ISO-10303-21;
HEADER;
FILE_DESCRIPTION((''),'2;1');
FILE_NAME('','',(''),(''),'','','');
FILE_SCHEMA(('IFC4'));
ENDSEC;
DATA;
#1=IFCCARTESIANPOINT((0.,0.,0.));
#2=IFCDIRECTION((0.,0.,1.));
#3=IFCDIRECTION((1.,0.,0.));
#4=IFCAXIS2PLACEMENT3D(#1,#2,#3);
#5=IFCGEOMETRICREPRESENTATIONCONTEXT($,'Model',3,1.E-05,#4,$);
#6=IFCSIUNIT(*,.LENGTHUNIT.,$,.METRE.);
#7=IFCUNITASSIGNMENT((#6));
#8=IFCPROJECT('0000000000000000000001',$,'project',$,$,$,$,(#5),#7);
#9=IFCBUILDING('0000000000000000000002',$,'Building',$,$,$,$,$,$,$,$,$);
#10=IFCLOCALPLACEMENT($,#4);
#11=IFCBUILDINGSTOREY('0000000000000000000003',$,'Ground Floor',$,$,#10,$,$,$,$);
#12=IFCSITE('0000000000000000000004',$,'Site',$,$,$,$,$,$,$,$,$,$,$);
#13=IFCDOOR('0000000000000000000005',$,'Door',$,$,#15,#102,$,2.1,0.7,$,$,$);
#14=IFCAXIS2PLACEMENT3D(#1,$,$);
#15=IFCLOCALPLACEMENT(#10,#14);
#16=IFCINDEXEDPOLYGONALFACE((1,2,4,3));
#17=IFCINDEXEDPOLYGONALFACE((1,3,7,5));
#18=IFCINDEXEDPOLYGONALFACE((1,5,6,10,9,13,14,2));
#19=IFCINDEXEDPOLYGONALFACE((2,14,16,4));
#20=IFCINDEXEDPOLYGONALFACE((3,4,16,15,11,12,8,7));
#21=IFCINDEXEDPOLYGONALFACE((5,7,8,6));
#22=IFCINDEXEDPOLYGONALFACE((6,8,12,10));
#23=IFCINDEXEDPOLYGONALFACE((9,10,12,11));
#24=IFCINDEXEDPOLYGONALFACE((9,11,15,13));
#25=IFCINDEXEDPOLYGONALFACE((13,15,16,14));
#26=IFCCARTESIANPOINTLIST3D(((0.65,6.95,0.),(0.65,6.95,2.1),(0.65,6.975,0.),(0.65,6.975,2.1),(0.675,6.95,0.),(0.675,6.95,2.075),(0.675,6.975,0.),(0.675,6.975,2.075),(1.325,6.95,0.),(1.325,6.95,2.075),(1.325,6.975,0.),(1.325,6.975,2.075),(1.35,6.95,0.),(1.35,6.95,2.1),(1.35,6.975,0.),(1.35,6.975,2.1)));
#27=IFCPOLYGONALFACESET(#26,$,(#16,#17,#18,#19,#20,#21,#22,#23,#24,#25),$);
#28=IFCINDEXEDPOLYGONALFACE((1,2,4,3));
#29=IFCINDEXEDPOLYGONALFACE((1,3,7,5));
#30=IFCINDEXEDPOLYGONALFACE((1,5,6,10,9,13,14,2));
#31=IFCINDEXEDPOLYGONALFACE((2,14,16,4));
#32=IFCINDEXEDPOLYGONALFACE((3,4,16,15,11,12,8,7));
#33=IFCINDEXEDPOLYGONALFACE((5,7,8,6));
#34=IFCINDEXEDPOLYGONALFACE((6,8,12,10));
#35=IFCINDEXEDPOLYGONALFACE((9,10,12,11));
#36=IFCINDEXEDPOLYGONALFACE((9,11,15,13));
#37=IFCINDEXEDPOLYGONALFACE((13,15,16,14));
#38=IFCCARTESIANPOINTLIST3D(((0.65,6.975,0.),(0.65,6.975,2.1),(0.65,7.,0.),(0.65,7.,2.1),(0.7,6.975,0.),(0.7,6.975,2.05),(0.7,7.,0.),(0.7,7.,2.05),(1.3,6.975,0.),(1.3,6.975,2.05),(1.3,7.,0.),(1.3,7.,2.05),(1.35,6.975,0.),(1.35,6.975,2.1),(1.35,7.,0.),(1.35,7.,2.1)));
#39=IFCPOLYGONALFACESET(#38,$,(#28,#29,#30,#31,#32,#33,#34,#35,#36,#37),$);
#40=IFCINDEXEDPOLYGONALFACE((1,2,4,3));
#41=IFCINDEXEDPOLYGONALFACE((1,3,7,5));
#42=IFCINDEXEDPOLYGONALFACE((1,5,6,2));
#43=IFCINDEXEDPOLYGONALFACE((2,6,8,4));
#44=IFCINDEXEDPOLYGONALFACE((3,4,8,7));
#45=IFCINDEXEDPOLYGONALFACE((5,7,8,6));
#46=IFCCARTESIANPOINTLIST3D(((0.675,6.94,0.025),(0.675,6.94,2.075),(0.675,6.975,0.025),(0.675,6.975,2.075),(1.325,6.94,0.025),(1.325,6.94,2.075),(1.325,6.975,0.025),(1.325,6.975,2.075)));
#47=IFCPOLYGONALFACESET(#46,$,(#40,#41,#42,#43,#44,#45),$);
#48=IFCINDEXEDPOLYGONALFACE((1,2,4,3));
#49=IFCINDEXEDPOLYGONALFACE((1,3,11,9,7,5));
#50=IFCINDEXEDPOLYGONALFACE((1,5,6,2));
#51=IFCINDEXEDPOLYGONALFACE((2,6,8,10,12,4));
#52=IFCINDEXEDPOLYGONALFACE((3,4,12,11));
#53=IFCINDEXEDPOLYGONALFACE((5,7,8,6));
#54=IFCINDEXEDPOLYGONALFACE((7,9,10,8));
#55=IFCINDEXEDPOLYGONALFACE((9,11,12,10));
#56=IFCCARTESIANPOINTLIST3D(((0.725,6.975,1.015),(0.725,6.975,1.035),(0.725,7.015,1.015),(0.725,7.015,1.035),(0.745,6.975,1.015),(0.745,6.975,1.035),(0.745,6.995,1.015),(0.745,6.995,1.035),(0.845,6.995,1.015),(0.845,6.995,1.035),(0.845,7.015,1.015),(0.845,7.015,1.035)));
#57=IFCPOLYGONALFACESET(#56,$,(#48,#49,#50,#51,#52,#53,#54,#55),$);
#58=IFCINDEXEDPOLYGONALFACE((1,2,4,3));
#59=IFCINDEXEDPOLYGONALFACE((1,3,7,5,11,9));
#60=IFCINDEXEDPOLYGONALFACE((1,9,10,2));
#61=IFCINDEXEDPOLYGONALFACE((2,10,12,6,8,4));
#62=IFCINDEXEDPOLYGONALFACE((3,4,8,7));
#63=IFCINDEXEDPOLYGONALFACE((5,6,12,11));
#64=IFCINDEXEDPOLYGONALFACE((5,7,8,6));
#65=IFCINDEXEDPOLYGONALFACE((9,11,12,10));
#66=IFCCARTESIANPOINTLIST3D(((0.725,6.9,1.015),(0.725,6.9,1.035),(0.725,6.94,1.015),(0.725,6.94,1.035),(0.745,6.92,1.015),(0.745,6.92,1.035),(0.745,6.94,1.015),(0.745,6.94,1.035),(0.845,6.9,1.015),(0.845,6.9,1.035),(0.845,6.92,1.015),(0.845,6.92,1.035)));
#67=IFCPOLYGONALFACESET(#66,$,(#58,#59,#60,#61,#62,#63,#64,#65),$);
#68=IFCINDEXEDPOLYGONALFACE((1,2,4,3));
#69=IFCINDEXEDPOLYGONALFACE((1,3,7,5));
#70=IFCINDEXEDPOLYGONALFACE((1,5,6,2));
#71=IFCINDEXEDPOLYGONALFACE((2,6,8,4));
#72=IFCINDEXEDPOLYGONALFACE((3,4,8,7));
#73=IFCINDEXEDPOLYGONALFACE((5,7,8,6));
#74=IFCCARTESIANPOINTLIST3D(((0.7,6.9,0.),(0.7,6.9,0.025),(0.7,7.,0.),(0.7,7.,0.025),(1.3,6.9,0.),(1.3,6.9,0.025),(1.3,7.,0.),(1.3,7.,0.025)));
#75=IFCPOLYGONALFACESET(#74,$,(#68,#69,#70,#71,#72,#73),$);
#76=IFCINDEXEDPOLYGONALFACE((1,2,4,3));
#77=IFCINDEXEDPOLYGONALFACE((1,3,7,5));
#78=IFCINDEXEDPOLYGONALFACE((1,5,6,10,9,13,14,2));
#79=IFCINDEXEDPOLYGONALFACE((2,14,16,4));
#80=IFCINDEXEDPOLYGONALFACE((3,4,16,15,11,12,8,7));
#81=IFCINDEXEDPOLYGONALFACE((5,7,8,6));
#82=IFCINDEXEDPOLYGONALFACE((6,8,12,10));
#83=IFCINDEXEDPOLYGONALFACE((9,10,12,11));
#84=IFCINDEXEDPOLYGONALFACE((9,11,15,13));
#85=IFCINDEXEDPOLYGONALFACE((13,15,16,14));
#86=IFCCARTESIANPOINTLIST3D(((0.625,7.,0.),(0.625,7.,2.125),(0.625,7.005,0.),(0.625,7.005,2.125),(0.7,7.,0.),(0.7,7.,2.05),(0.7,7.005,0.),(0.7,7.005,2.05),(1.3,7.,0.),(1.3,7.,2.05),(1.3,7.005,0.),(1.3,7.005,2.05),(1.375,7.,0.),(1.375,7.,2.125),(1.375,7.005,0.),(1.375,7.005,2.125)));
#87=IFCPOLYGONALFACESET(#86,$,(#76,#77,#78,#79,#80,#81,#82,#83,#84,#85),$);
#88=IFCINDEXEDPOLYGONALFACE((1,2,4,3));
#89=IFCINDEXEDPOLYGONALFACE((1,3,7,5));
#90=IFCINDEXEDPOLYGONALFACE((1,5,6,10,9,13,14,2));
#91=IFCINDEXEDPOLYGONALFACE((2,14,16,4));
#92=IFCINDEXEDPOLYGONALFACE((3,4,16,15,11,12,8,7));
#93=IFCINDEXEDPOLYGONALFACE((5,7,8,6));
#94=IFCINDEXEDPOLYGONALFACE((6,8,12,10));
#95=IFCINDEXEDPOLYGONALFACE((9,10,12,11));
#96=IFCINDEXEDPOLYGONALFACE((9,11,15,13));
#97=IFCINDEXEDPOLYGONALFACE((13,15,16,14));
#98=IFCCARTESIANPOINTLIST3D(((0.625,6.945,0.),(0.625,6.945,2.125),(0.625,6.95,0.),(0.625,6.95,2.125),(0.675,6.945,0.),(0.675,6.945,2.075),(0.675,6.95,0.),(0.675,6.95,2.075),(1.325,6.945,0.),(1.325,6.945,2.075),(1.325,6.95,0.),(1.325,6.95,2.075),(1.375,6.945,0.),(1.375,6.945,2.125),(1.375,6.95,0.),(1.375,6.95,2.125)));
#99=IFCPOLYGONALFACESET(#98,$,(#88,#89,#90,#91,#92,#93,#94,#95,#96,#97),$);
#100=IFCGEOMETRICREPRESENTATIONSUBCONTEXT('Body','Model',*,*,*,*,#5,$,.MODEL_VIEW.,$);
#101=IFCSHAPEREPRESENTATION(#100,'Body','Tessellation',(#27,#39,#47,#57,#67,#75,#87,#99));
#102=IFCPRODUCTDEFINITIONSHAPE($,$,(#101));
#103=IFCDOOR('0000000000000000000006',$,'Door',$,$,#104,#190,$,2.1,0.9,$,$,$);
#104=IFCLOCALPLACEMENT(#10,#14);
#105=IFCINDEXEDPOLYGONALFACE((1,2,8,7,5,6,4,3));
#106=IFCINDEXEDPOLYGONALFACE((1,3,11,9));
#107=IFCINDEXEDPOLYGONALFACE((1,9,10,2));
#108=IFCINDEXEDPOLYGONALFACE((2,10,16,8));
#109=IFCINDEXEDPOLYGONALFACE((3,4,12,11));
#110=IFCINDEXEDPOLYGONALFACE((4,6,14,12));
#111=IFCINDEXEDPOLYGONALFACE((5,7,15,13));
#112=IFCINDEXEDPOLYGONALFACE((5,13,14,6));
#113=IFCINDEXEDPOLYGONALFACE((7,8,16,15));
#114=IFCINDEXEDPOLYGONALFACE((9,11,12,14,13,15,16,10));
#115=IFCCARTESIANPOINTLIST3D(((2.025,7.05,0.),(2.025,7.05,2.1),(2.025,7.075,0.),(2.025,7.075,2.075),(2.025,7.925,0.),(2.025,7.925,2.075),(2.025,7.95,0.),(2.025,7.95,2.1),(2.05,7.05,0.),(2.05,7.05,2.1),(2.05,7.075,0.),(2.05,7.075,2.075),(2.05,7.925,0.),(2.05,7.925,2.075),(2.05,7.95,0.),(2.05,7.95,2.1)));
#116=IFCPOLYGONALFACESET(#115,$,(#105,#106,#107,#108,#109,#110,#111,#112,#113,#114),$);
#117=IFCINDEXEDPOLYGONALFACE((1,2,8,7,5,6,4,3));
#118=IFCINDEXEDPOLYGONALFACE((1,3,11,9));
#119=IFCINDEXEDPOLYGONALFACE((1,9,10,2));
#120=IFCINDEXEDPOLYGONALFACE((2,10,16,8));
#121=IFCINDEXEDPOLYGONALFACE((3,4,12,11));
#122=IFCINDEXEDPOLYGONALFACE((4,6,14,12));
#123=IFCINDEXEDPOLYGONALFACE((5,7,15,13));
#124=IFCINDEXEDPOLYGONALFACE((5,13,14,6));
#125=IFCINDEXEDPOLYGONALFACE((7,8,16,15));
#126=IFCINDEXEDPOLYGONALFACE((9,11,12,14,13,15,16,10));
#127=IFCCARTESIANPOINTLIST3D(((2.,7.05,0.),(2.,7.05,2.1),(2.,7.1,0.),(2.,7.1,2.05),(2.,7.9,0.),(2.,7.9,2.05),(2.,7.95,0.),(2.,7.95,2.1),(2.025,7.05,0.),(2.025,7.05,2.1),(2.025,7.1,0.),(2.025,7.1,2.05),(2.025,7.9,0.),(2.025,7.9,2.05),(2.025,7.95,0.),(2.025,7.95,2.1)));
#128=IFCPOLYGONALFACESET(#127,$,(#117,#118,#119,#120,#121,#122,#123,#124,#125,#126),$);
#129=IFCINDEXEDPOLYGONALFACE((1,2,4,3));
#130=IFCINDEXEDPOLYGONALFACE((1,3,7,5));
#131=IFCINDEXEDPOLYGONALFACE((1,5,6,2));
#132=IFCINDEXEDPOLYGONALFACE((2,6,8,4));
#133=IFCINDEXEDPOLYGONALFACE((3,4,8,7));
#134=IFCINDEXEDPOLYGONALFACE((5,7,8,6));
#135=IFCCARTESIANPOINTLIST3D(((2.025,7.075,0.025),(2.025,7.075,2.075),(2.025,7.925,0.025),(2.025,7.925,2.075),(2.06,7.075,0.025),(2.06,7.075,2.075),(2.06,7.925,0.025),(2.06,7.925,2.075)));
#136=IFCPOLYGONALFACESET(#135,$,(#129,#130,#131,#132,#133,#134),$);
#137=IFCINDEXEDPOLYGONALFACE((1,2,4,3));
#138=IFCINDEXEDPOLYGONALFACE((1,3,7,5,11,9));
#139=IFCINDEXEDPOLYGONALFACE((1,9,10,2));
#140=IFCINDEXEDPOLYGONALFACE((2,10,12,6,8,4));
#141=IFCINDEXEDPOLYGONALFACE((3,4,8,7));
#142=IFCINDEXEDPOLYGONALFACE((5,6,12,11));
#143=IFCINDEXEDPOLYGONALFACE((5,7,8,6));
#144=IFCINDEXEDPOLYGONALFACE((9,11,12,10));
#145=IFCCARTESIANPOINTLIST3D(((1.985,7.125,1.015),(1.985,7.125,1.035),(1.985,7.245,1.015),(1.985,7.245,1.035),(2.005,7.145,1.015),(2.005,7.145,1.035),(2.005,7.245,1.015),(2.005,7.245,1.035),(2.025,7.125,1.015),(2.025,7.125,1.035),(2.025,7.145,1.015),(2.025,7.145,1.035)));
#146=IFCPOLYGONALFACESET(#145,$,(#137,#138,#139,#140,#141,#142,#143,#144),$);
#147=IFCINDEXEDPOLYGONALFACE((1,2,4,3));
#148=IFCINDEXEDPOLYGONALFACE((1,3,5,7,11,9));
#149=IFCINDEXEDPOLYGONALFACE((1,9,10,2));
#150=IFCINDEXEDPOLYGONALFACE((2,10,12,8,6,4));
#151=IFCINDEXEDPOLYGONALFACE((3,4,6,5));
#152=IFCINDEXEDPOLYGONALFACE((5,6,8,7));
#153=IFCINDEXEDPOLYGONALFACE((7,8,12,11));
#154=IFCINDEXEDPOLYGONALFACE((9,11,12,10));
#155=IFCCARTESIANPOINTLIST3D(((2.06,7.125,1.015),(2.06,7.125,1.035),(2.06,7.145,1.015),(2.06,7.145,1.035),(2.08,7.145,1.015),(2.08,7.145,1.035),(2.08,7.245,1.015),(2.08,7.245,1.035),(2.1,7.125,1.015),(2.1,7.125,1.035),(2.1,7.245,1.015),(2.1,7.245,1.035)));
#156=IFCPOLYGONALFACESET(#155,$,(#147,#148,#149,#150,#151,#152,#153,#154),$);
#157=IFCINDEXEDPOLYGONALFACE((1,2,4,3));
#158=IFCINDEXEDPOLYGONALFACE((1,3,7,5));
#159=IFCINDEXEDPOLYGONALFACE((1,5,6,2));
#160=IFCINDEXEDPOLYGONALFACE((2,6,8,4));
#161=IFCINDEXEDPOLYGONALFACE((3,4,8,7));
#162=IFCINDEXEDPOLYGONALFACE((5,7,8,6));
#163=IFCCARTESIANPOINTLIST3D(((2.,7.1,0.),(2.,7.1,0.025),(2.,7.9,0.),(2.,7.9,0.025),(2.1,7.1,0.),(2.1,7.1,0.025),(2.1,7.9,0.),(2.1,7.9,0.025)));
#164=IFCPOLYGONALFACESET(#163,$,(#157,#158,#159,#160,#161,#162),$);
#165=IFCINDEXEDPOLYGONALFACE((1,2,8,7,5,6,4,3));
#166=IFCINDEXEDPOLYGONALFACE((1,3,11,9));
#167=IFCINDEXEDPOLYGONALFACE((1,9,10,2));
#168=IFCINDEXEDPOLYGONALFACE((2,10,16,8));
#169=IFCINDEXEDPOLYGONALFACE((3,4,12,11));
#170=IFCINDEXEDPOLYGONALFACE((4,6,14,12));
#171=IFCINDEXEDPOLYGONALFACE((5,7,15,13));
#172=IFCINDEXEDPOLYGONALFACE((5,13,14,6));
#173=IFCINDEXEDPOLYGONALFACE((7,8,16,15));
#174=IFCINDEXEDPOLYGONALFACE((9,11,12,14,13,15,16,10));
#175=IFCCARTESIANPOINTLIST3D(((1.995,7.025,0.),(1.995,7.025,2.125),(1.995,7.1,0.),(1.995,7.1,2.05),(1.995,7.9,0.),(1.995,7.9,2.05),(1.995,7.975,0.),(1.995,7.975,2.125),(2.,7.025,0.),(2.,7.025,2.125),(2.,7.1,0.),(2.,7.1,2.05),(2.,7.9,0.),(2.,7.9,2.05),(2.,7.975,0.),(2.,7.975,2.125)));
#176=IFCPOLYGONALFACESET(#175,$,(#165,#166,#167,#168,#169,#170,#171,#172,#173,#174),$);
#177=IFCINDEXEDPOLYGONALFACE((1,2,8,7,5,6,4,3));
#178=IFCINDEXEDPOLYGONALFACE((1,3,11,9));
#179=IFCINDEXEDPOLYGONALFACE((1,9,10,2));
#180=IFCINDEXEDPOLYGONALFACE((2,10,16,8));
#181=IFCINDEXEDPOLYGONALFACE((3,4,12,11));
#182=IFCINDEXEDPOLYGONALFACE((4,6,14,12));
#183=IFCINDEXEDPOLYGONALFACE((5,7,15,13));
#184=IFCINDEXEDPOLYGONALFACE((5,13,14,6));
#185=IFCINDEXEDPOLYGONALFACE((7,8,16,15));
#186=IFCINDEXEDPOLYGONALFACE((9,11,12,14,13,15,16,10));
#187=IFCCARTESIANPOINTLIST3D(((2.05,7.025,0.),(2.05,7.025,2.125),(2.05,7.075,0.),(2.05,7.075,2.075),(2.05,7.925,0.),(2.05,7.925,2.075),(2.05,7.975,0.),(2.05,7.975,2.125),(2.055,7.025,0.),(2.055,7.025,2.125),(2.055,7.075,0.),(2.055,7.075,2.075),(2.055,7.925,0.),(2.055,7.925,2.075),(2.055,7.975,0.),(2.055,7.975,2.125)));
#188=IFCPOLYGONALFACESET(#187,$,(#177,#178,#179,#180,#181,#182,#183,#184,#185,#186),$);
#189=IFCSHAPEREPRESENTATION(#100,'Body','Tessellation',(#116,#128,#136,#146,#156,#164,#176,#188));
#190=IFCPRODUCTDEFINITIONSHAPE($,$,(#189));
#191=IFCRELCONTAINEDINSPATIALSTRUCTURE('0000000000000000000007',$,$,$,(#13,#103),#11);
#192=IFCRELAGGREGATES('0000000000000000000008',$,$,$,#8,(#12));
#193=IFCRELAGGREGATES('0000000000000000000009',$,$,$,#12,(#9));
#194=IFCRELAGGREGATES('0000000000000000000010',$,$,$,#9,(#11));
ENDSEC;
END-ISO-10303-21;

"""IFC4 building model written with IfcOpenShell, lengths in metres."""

from ifc_helpers import new_model, si_unit, frame, origin_with_axes, place, context, subcontext, project, spatial, line, indexed_curve, outline, extrude, element, save


model = new_model("IFC4")

# Units and contexts
model_context = context("Model", 3, precision=1e-05, world=origin_with_axes())
body_context = subcontext(model_context, "Body", "Model", "MODEL_VIEW")
ifc_project = project(units=[si_unit("LENGTHUNIT", "METRE")], contexts=[model_context])

# Site, building, storey
site = spatial("IfcSite", under=ifc_project, Name="Site")
building = spatial("IfcBuilding", under=site, Name="Building")
storey_placement = place(None, origin_with_axes())
storey = spatial("IfcBuildingStorey", under=building, at=storey_placement, Name="Ground Floor")

# Doors
door_1_placement = place(storey_placement, frame((1.35, 7.0, 0.0), z_axis=(0.0, 0.0, 1.0), x_axis=(-1.0, 0.0, 0.0)))
element("IfcDoor", 1, at=door_1_placement, inside=storey, Name="Door", OverallHeight=2.1, OverallWidth=0.7, context=body_context, shape_type="SweptSolid", body=[
    extrude(outline(indexed_curve([(0.0, 0.0), (0.0, 2.1), (0.7, 2.1), (0.7, 0.0), (0.675, 0.0), (0.675, 2.075), (0.025, 2.075), (0.025, 0.0)], segments=[line(1, 2, 3, 4, 5, 6, 7, 8, 1)])), frame((0.0, 0.025, 0.0), z_axis=(0.0, -1.0, 0.0), x_axis=(1.0, 0.0, 0.0)), (0.0, 0.0, -1.0), 0.025),
    extrude(outline(indexed_curve([(0.0, 0.0), (0.0, 2.1), (0.7, 2.1), (0.7, 0.0), (0.65, 0.0), (0.65, 2.05), (0.05, 2.05), (0.05, 0.0)], segments=[line(1, 2, 3, 4, 5, 6, 7, 8, 1)])), frame((0.0, 0.0, 0.0), z_axis=(0.0, -1.0, 0.0), x_axis=(1.0, 0.0, 0.0)), (0.0, 0.0, -1.0), 0.025),
    extrude(outline(indexed_curve([(0.0, 0.0), (0.65, 0.0), (0.65, 0.035), (0.0, 0.035)], segments=[line(1, 2, 3, 4, 1)])), frame((0.025, 0.025, 0.025), z_axis=(0.0, 0.0, 1.0), x_axis=(1.0, 0.0, 0.0)), (0.0, 0.0, 1.0), 2.05),
    extrude(outline(indexed_curve([(0.0, 0.0), (0.0, -0.04), (-0.12, -0.04), (-0.12, -0.02), (-0.02, -0.02), (-0.02, 0.0)], segments=[line(1, 2, 3, 4, 5, 6, 1)])), frame((0.625, 0.025, 1.015), z_axis=(0.0, 0.0, 1.0), x_axis=(1.0, 0.0, 0.0)), (0.0, 0.0, 1.0), 0.02),
    extrude(outline(indexed_curve([(0.0, 0.0), (0.0, 0.04), (-0.12, 0.04), (-0.12, 0.02), (-0.02, 0.02), (-0.02, 0.0)], segments=[line(1, 2, 3, 4, 5, 6, 1)])), frame((0.625, 0.06, 1.015), z_axis=(0.0, 0.0, 1.0), x_axis=(1.0, 0.0, 0.0)), (0.0, 0.0, 1.0), 0.02),
    extrude(outline(indexed_curve([(0.0, 0.0), (0.6, 0.0), (0.6, 0.1), (0.0, 0.1)], segments=[line(1, 2, 3, 4, 1)])), frame((0.05, 0.0, 0.0), z_axis=(0.0, 0.0, 1.0), x_axis=(1.0, 0.0, 0.0)), (0.0, 0.0, 1.0), 0.025),
    extrude(outline(indexed_curve([(0.0, 0.0), (0.0, 2.125), (0.75, 2.125), (0.75, 0.0), (0.675, 0.0), (0.675, 2.05), (0.075, 2.05), (0.075, 0.0)], segments=[line(1, 2, 3, 4, 5, 6, 7, 8, 1)])), frame((-0.025, -0.005, 0.0), z_axis=(0.0, -1.0, 0.0), x_axis=(1.0, 0.0, 0.0)), (0.0, 0.0, -1.0), 0.005),
    extrude(outline(indexed_curve([(0.0, 0.0), (0.0, 2.125), (0.75, 2.125), (0.75, 0.0), (0.7, 0.0), (0.7, 2.075), (0.05, 2.075), (0.05, 0.0)], segments=[line(1, 2, 3, 4, 5, 6, 7, 8, 1)])), frame((-0.025, 0.05, 0.0), z_axis=(0.0, -1.0, 0.0), x_axis=(1.0, 0.0, 0.0)), (0.0, 0.0, -1.0), 0.005),
])
door_2_placement = place(storey_placement, frame((2.0, 7.95, 0.0), z_axis=(0.0, 0.0, 1.0), x_axis=(0.0, -1.0, 0.0)))
element("IfcDoor", 2, at=door_2_placement, inside=storey, Name="Door", OverallHeight=2.1, OverallWidth=0.9, context=body_context, shape_type="SweptSolid", body=[
    extrude(outline(indexed_curve([(0.0, 0.0), (0.0, 2.1), (0.9, 2.1), (0.9, 0.0), (0.875, 0.0), (0.875, 2.075), (0.025, 2.075), (0.025, 0.0)], segments=[line(1, 2, 3, 4, 5, 6, 7, 8, 1)])), frame((0.0, 0.025, 0.0), z_axis=(0.0, -1.0, 0.0), x_axis=(1.0, 0.0, 0.0)), (0.0, 0.0, -1.0), 0.025),
    extrude(outline(indexed_curve([(0.0, 0.0), (0.0, 2.1), (0.9, 2.1), (0.9, 0.0), (0.85, 0.0), (0.85, 2.05), (0.05, 2.05), (0.05, 0.0)], segments=[line(1, 2, 3, 4, 5, 6, 7, 8, 1)])), frame((0.0, 0.0, 0.0), z_axis=(0.0, -1.0, 0.0), x_axis=(1.0, 0.0, 0.0)), (0.0, 0.0, -1.0), 0.025),
    extrude(outline(indexed_curve([(0.0, 0.0), (0.85, 0.0), (0.85, 0.035), (0.0, 0.035)], segments=[line(1, 2, 3, 4, 1)])), frame((0.025, 0.025, 0.025), z_axis=(0.0, 0.0, 1.0), x_axis=(1.0, 0.0, 0.0)), (0.0, 0.0, 1.0), 2.05),
    extrude(outline(indexed_curve([(0.0, 0.0), (0.0, -0.04), (-0.12, -0.04), (-0.12, -0.02), (-0.02, -0.02), (-0.02, 0.0)], segments=[line(1, 2, 3, 4, 5, 6, 1)])), frame((0.825, 0.025, 1.015), z_axis=(0.0, 0.0, 1.0), x_axis=(1.0, 0.0, 0.0)), (0.0, 0.0, 1.0), 0.02),
    extrude(outline(indexed_curve([(0.0, 0.0), (0.0, 0.04), (-0.12, 0.04), (-0.12, 0.02), (-0.02, 0.02), (-0.02, 0.0)], segments=[line(1, 2, 3, 4, 5, 6, 1)])), frame((0.825, 0.06, 1.015), z_axis=(0.0, 0.0, 1.0), x_axis=(1.0, 0.0, 0.0)), (0.0, 0.0, 1.0), 0.02),
    extrude(outline(indexed_curve([(0.0, 0.0), (0.8, 0.0), (0.8, 0.1), (0.0, 0.1)], segments=[line(1, 2, 3, 4, 1)])), frame((0.05, 0.0, 0.0), z_axis=(0.0, 0.0, 1.0), x_axis=(1.0, 0.0, 0.0)), (0.0, 0.0, 1.0), 0.025),
    extrude(outline(indexed_curve([(0.0, 0.0), (0.0, 2.125), (0.95, 2.125), (0.95, 0.0), (0.875, 0.0), (0.875, 2.05), (0.075, 2.05), (0.075, 0.0)], segments=[line(1, 2, 3, 4, 5, 6, 7, 8, 1)])), frame((-0.025, -0.005, 0.0), z_axis=(0.0, -1.0, 0.0), x_axis=(1.0, 0.0, 0.0)), (0.0, 0.0, -1.0), 0.005),
    extrude(outline(indexed_curve([(0.0, 0.0), (0.0, 2.125), (0.95, 2.125), (0.95, 0.0), (0.9, 0.0), (0.9, 2.075), (0.05, 2.075), (0.05, 0.0)], segments=[line(1, 2, 3, 4, 5, 6, 7, 8, 1)])), frame((-0.025, 0.05, 0.0), z_axis=(0.0, -1.0, 0.0), x_axis=(1.0, 0.0, 0.0)), (0.0, 0.0, -1.0), 0.005),
])

save(model, "model.ifc")
